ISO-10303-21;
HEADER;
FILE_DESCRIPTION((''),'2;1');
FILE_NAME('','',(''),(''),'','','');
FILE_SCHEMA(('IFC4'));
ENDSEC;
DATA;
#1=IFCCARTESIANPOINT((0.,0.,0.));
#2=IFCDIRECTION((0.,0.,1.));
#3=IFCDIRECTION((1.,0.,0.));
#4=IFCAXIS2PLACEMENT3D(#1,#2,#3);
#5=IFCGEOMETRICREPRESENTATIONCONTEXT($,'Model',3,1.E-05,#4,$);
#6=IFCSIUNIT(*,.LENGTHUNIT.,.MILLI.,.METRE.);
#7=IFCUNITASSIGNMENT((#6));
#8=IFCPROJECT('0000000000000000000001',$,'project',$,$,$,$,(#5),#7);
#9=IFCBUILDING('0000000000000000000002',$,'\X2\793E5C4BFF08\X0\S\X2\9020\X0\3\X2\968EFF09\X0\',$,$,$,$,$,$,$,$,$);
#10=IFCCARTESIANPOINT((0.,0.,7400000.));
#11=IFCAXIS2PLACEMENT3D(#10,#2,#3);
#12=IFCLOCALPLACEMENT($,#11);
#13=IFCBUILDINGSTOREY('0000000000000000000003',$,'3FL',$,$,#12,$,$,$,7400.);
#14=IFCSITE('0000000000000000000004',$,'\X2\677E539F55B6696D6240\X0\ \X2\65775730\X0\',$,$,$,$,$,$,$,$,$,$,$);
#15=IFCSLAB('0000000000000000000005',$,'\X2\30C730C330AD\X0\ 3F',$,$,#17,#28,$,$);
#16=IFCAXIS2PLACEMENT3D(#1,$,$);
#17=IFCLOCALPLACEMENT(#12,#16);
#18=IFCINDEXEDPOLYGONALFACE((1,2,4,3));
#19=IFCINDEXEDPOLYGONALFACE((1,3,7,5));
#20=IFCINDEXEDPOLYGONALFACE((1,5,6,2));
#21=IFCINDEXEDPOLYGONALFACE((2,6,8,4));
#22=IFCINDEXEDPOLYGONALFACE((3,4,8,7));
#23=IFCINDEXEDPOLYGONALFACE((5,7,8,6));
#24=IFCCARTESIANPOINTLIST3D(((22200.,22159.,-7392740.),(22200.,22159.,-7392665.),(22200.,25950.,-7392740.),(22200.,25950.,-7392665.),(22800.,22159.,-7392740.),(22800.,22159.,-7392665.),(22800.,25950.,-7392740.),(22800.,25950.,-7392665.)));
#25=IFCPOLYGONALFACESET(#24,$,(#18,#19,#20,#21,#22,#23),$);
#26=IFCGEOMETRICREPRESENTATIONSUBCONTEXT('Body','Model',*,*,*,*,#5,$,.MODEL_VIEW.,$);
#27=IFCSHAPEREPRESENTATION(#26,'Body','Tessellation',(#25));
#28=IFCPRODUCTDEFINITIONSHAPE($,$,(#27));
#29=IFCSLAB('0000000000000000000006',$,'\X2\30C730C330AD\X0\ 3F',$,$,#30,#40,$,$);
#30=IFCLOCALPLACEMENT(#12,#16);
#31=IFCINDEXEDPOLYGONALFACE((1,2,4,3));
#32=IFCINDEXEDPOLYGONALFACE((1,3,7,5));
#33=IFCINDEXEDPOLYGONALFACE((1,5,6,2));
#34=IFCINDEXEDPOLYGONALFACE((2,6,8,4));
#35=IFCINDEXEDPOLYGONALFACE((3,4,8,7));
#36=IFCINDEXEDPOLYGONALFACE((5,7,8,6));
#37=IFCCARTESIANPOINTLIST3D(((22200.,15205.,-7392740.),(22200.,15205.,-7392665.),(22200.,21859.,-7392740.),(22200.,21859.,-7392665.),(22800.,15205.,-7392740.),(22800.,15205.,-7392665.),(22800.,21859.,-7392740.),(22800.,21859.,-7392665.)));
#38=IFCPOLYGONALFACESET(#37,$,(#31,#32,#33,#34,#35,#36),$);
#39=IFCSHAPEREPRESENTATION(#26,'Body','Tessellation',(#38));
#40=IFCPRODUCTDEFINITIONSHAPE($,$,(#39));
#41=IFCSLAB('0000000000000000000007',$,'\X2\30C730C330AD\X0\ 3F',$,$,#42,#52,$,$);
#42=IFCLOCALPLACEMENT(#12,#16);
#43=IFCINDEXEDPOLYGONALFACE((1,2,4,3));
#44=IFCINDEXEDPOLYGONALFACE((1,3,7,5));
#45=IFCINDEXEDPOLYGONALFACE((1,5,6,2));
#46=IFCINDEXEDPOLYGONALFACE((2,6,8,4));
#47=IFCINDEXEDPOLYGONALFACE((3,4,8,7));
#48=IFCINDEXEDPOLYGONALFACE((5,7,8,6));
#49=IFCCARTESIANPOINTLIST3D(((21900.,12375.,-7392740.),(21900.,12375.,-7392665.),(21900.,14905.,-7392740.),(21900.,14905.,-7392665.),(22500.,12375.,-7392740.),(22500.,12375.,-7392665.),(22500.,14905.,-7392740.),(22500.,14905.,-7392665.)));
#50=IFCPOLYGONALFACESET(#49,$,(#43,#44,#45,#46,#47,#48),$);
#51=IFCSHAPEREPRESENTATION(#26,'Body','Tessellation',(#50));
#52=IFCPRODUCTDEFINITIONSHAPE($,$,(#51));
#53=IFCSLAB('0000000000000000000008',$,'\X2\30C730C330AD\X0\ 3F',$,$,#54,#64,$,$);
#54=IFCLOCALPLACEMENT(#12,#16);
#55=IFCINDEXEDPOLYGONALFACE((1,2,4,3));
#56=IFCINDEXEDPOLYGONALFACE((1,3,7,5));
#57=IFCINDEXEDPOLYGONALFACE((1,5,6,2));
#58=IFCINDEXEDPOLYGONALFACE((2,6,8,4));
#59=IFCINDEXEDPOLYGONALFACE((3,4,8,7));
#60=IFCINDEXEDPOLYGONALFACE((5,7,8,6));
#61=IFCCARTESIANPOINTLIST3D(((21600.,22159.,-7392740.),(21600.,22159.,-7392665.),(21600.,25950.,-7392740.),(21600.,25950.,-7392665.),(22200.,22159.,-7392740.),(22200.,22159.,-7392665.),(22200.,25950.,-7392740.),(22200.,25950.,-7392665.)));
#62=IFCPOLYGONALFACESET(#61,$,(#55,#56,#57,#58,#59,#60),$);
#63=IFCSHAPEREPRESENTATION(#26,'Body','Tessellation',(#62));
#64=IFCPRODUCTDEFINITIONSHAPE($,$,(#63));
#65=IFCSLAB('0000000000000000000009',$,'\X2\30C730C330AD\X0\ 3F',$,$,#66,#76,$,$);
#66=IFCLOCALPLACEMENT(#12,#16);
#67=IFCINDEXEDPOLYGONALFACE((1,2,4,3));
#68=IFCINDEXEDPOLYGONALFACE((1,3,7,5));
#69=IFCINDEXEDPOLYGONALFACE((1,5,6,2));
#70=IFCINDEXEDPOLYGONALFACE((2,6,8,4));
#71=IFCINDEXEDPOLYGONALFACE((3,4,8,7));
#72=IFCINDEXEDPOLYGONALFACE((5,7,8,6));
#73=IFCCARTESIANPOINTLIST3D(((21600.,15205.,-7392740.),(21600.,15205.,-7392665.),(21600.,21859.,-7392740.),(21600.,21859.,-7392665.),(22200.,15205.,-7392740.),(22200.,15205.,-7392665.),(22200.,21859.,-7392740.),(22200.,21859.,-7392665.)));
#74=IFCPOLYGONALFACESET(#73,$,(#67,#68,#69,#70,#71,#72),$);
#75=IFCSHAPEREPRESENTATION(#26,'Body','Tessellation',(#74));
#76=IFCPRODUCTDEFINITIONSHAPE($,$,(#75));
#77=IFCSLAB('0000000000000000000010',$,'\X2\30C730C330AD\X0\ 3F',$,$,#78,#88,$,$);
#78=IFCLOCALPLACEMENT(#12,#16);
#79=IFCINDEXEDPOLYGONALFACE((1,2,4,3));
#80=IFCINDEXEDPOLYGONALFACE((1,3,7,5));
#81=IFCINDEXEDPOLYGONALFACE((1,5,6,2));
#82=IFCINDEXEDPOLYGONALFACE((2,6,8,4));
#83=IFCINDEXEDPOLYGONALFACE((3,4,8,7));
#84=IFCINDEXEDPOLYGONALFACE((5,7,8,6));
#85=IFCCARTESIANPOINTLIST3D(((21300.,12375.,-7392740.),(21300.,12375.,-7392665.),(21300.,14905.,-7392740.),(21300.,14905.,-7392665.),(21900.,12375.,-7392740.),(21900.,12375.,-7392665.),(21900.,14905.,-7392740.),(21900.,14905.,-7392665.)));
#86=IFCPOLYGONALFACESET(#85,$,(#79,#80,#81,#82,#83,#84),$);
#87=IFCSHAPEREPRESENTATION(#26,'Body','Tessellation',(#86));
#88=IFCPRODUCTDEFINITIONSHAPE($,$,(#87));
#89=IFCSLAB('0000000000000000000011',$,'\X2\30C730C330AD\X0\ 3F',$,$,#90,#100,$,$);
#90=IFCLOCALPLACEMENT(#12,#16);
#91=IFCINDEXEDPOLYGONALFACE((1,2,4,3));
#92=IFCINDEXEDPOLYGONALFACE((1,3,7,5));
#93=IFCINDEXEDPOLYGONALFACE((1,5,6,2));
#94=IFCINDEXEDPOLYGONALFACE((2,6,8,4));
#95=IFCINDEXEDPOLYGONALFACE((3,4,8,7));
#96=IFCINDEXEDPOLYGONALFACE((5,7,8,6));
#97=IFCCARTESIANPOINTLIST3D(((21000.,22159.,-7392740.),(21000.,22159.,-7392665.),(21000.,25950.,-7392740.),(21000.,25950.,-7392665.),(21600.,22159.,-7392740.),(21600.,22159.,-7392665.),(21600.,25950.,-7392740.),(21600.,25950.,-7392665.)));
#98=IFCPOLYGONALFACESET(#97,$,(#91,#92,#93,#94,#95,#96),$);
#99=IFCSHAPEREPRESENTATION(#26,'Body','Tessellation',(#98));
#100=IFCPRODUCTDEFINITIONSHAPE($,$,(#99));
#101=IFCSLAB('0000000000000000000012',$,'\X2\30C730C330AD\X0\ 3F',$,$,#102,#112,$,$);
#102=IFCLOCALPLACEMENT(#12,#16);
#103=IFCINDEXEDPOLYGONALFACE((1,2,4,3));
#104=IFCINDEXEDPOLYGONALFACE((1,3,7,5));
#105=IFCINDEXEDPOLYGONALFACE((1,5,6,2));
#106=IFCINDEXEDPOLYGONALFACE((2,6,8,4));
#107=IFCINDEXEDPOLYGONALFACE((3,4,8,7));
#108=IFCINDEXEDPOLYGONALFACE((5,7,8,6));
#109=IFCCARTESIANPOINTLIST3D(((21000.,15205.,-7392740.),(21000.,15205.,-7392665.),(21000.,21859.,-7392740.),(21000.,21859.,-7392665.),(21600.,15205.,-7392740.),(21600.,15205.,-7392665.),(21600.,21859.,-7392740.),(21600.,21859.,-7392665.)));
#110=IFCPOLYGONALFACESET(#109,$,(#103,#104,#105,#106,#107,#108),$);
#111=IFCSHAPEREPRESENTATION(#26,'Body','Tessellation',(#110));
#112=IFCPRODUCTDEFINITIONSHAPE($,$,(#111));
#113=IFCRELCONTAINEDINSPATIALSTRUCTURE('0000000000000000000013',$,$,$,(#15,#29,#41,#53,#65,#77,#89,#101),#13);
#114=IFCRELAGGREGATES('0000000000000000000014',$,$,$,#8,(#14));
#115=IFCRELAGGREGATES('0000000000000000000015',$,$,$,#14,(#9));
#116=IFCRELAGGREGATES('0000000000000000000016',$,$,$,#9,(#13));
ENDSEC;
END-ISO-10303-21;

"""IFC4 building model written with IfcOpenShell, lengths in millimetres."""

from ifc_helpers import new_model, si_unit, frame, origin, origin_with_axes, place, context, subcontext, project, spatial, polyline, outline, extrude, element, save


model = new_model("IFC4")

# Units and contexts
model_context = context("Model", 3, precision=1e-05, world=origin_with_axes())
body_context = subcontext(model_context, "Body", "Model", "MODEL_VIEW")
ifc_project = project(units=[si_unit("LENGTHUNIT", "METRE", prefix="MILLI")], contexts=[model_context])

# Site, building, storey
site = spatial("IfcSite", under=ifc_project, Name="松原営業所 敷地")
building = spatial("IfcBuilding", under=site, Name="社屋（S造3階）")
storey_placement = place(None, frame((0.0, 0.0, 7400000.0), z_axis=(0.0, 0.0, 1.0), x_axis=(1.0, 0.0, 0.0)))
storey = spatial("IfcBuildingStorey", under=building, at=storey_placement, Name="3FL", Elevation=7400.0)

# Slabs
slab_1_placement = place(storey_placement, frame((0.0, 0.0, -7392740.0), z_axis=(0.0, 0.0, 1.0), x_axis=(1.0, 0.0, 0.0)))
element("IfcSlab", 1, at=slab_1_placement, inside=storey, Name="デッキ 3F", context=body_context, shape_type="SweptSolid", body=[
    extrude(outline(polyline([(22800.0, 22159.0), (22800.0, 25950.0), (22200.0, 25950.0), (22200.0, 22159.0), (22800.0, 22159.0)])), origin(), (0.0, 0.0, 1.0), 75.0),
])
slab_2_placement = place(storey_placement, frame((0.0, 0.0, -7392740.0), z_axis=(0.0, 0.0, 1.0), x_axis=(1.0, 0.0, 0.0)))
element("IfcSlab", 2, at=slab_2_placement, inside=storey, Name="デッキ 3F", context=body_context, shape_type="SweptSolid", body=[
    extrude(outline(polyline([(22800.0, 15205.0), (22800.0, 21859.0), (22200.0, 21859.0), (22200.0, 15205.0), (22800.0, 15205.0)])), origin(), (0.0, 0.0, 1.0), 75.0),
])
slab_3_placement = place(storey_placement, frame((0.0, 0.0, -7392740.0), z_axis=(0.0, 0.0, 1.0), x_axis=(1.0, 0.0, 0.0)))
element("IfcSlab", 3, at=slab_3_placement, inside=storey, Name="デッキ 3F", context=body_context, shape_type="SweptSolid", body=[
    extrude(outline(polyline([(22500.0, 12375.0), (22500.0, 14905.0), (21900.0, 14905.0), (21900.0, 12375.0), (22500.0, 12375.0)])), origin(), (0.0, 0.0, 1.0), 75.0),
])
slab_4_placement = place(storey_placement, frame((0.0, 0.0, -7392740.0), z_axis=(0.0, 0.0, 1.0), x_axis=(1.0, 0.0, 0.0)))
element("IfcSlab", 4, at=slab_4_placement, inside=storey, Name="デッキ 3F", context=body_context, shape_type="SweptSolid", body=[
    extrude(outline(polyline([(22200.0, 22159.0), (22200.0, 25950.0), (21600.0, 25950.0), (21600.0, 22159.0), (22200.0, 22159.0)])), origin(), (0.0, 0.0, 1.0), 75.0),
])
slab_5_placement = place(storey_placement, frame((0.0, 0.0, -7392740.0), z_axis=(0.0, 0.0, 1.0), x_axis=(1.0, 0.0, 0.0)))
element("IfcSlab", 5, at=slab_5_placement, inside=storey, Name="デッキ 3F", context=body_context, shape_type="SweptSolid", body=[
    extrude(outline(polyline([(22200.0, 15205.0), (22200.0, 21859.0), (21600.0, 21859.0), (21600.0, 15205.0), (22200.0, 15205.0)])), origin(), (0.0, 0.0, 1.0), 75.0),
])
slab_6_placement = place(storey_placement, frame((0.0, 0.0, -7392740.0), z_axis=(0.0, 0.0, 1.0), x_axis=(1.0, 0.0, 0.0)))
element("IfcSlab", 6, at=slab_6_placement, inside=storey, Name="デッキ 3F", context=body_context, shape_type="SweptSolid", body=[
    extrude(outline(polyline([(21900.0, 12375.0), (21900.0, 14905.0), (21300.0, 14905.0), (21300.0, 12375.0), (21900.0, 12375.0)])), origin(), (0.0, 0.0, 1.0), 75.0),
])
slab_7_placement = place(storey_placement, frame((0.0, 0.0, -7392740.0), z_axis=(0.0, 0.0, 1.0), x_axis=(1.0, 0.0, 0.0)))
element("IfcSlab", 7, at=slab_7_placement, inside=storey, Name="デッキ 3F", context=body_context, shape_type="SweptSolid", body=[
    extrude(outline(polyline([(21600.0, 22159.0), (21600.0, 25950.0), (21000.0, 25950.0), (21000.0, 22159.0), (21600.0, 22159.0)])), origin(), (0.0, 0.0, 1.0), 75.0),
])
slab_8_placement = place(storey_placement, frame((0.0, 0.0, -7392740.0), z_axis=(0.0, 0.0, 1.0), x_axis=(1.0, 0.0, 0.0)))
element("IfcSlab", 8, at=slab_8_placement, inside=storey, Name="デッキ 3F", context=body_context, shape_type="SweptSolid", body=[
    extrude(outline(polyline([(21600.0, 15205.0), (21600.0, 21859.0), (21000.0, 21859.0), (21000.0, 15205.0), (21600.0, 15205.0)])), origin(), (0.0, 0.0, 1.0), 75.0),
])

save(model, "model.ifc")
